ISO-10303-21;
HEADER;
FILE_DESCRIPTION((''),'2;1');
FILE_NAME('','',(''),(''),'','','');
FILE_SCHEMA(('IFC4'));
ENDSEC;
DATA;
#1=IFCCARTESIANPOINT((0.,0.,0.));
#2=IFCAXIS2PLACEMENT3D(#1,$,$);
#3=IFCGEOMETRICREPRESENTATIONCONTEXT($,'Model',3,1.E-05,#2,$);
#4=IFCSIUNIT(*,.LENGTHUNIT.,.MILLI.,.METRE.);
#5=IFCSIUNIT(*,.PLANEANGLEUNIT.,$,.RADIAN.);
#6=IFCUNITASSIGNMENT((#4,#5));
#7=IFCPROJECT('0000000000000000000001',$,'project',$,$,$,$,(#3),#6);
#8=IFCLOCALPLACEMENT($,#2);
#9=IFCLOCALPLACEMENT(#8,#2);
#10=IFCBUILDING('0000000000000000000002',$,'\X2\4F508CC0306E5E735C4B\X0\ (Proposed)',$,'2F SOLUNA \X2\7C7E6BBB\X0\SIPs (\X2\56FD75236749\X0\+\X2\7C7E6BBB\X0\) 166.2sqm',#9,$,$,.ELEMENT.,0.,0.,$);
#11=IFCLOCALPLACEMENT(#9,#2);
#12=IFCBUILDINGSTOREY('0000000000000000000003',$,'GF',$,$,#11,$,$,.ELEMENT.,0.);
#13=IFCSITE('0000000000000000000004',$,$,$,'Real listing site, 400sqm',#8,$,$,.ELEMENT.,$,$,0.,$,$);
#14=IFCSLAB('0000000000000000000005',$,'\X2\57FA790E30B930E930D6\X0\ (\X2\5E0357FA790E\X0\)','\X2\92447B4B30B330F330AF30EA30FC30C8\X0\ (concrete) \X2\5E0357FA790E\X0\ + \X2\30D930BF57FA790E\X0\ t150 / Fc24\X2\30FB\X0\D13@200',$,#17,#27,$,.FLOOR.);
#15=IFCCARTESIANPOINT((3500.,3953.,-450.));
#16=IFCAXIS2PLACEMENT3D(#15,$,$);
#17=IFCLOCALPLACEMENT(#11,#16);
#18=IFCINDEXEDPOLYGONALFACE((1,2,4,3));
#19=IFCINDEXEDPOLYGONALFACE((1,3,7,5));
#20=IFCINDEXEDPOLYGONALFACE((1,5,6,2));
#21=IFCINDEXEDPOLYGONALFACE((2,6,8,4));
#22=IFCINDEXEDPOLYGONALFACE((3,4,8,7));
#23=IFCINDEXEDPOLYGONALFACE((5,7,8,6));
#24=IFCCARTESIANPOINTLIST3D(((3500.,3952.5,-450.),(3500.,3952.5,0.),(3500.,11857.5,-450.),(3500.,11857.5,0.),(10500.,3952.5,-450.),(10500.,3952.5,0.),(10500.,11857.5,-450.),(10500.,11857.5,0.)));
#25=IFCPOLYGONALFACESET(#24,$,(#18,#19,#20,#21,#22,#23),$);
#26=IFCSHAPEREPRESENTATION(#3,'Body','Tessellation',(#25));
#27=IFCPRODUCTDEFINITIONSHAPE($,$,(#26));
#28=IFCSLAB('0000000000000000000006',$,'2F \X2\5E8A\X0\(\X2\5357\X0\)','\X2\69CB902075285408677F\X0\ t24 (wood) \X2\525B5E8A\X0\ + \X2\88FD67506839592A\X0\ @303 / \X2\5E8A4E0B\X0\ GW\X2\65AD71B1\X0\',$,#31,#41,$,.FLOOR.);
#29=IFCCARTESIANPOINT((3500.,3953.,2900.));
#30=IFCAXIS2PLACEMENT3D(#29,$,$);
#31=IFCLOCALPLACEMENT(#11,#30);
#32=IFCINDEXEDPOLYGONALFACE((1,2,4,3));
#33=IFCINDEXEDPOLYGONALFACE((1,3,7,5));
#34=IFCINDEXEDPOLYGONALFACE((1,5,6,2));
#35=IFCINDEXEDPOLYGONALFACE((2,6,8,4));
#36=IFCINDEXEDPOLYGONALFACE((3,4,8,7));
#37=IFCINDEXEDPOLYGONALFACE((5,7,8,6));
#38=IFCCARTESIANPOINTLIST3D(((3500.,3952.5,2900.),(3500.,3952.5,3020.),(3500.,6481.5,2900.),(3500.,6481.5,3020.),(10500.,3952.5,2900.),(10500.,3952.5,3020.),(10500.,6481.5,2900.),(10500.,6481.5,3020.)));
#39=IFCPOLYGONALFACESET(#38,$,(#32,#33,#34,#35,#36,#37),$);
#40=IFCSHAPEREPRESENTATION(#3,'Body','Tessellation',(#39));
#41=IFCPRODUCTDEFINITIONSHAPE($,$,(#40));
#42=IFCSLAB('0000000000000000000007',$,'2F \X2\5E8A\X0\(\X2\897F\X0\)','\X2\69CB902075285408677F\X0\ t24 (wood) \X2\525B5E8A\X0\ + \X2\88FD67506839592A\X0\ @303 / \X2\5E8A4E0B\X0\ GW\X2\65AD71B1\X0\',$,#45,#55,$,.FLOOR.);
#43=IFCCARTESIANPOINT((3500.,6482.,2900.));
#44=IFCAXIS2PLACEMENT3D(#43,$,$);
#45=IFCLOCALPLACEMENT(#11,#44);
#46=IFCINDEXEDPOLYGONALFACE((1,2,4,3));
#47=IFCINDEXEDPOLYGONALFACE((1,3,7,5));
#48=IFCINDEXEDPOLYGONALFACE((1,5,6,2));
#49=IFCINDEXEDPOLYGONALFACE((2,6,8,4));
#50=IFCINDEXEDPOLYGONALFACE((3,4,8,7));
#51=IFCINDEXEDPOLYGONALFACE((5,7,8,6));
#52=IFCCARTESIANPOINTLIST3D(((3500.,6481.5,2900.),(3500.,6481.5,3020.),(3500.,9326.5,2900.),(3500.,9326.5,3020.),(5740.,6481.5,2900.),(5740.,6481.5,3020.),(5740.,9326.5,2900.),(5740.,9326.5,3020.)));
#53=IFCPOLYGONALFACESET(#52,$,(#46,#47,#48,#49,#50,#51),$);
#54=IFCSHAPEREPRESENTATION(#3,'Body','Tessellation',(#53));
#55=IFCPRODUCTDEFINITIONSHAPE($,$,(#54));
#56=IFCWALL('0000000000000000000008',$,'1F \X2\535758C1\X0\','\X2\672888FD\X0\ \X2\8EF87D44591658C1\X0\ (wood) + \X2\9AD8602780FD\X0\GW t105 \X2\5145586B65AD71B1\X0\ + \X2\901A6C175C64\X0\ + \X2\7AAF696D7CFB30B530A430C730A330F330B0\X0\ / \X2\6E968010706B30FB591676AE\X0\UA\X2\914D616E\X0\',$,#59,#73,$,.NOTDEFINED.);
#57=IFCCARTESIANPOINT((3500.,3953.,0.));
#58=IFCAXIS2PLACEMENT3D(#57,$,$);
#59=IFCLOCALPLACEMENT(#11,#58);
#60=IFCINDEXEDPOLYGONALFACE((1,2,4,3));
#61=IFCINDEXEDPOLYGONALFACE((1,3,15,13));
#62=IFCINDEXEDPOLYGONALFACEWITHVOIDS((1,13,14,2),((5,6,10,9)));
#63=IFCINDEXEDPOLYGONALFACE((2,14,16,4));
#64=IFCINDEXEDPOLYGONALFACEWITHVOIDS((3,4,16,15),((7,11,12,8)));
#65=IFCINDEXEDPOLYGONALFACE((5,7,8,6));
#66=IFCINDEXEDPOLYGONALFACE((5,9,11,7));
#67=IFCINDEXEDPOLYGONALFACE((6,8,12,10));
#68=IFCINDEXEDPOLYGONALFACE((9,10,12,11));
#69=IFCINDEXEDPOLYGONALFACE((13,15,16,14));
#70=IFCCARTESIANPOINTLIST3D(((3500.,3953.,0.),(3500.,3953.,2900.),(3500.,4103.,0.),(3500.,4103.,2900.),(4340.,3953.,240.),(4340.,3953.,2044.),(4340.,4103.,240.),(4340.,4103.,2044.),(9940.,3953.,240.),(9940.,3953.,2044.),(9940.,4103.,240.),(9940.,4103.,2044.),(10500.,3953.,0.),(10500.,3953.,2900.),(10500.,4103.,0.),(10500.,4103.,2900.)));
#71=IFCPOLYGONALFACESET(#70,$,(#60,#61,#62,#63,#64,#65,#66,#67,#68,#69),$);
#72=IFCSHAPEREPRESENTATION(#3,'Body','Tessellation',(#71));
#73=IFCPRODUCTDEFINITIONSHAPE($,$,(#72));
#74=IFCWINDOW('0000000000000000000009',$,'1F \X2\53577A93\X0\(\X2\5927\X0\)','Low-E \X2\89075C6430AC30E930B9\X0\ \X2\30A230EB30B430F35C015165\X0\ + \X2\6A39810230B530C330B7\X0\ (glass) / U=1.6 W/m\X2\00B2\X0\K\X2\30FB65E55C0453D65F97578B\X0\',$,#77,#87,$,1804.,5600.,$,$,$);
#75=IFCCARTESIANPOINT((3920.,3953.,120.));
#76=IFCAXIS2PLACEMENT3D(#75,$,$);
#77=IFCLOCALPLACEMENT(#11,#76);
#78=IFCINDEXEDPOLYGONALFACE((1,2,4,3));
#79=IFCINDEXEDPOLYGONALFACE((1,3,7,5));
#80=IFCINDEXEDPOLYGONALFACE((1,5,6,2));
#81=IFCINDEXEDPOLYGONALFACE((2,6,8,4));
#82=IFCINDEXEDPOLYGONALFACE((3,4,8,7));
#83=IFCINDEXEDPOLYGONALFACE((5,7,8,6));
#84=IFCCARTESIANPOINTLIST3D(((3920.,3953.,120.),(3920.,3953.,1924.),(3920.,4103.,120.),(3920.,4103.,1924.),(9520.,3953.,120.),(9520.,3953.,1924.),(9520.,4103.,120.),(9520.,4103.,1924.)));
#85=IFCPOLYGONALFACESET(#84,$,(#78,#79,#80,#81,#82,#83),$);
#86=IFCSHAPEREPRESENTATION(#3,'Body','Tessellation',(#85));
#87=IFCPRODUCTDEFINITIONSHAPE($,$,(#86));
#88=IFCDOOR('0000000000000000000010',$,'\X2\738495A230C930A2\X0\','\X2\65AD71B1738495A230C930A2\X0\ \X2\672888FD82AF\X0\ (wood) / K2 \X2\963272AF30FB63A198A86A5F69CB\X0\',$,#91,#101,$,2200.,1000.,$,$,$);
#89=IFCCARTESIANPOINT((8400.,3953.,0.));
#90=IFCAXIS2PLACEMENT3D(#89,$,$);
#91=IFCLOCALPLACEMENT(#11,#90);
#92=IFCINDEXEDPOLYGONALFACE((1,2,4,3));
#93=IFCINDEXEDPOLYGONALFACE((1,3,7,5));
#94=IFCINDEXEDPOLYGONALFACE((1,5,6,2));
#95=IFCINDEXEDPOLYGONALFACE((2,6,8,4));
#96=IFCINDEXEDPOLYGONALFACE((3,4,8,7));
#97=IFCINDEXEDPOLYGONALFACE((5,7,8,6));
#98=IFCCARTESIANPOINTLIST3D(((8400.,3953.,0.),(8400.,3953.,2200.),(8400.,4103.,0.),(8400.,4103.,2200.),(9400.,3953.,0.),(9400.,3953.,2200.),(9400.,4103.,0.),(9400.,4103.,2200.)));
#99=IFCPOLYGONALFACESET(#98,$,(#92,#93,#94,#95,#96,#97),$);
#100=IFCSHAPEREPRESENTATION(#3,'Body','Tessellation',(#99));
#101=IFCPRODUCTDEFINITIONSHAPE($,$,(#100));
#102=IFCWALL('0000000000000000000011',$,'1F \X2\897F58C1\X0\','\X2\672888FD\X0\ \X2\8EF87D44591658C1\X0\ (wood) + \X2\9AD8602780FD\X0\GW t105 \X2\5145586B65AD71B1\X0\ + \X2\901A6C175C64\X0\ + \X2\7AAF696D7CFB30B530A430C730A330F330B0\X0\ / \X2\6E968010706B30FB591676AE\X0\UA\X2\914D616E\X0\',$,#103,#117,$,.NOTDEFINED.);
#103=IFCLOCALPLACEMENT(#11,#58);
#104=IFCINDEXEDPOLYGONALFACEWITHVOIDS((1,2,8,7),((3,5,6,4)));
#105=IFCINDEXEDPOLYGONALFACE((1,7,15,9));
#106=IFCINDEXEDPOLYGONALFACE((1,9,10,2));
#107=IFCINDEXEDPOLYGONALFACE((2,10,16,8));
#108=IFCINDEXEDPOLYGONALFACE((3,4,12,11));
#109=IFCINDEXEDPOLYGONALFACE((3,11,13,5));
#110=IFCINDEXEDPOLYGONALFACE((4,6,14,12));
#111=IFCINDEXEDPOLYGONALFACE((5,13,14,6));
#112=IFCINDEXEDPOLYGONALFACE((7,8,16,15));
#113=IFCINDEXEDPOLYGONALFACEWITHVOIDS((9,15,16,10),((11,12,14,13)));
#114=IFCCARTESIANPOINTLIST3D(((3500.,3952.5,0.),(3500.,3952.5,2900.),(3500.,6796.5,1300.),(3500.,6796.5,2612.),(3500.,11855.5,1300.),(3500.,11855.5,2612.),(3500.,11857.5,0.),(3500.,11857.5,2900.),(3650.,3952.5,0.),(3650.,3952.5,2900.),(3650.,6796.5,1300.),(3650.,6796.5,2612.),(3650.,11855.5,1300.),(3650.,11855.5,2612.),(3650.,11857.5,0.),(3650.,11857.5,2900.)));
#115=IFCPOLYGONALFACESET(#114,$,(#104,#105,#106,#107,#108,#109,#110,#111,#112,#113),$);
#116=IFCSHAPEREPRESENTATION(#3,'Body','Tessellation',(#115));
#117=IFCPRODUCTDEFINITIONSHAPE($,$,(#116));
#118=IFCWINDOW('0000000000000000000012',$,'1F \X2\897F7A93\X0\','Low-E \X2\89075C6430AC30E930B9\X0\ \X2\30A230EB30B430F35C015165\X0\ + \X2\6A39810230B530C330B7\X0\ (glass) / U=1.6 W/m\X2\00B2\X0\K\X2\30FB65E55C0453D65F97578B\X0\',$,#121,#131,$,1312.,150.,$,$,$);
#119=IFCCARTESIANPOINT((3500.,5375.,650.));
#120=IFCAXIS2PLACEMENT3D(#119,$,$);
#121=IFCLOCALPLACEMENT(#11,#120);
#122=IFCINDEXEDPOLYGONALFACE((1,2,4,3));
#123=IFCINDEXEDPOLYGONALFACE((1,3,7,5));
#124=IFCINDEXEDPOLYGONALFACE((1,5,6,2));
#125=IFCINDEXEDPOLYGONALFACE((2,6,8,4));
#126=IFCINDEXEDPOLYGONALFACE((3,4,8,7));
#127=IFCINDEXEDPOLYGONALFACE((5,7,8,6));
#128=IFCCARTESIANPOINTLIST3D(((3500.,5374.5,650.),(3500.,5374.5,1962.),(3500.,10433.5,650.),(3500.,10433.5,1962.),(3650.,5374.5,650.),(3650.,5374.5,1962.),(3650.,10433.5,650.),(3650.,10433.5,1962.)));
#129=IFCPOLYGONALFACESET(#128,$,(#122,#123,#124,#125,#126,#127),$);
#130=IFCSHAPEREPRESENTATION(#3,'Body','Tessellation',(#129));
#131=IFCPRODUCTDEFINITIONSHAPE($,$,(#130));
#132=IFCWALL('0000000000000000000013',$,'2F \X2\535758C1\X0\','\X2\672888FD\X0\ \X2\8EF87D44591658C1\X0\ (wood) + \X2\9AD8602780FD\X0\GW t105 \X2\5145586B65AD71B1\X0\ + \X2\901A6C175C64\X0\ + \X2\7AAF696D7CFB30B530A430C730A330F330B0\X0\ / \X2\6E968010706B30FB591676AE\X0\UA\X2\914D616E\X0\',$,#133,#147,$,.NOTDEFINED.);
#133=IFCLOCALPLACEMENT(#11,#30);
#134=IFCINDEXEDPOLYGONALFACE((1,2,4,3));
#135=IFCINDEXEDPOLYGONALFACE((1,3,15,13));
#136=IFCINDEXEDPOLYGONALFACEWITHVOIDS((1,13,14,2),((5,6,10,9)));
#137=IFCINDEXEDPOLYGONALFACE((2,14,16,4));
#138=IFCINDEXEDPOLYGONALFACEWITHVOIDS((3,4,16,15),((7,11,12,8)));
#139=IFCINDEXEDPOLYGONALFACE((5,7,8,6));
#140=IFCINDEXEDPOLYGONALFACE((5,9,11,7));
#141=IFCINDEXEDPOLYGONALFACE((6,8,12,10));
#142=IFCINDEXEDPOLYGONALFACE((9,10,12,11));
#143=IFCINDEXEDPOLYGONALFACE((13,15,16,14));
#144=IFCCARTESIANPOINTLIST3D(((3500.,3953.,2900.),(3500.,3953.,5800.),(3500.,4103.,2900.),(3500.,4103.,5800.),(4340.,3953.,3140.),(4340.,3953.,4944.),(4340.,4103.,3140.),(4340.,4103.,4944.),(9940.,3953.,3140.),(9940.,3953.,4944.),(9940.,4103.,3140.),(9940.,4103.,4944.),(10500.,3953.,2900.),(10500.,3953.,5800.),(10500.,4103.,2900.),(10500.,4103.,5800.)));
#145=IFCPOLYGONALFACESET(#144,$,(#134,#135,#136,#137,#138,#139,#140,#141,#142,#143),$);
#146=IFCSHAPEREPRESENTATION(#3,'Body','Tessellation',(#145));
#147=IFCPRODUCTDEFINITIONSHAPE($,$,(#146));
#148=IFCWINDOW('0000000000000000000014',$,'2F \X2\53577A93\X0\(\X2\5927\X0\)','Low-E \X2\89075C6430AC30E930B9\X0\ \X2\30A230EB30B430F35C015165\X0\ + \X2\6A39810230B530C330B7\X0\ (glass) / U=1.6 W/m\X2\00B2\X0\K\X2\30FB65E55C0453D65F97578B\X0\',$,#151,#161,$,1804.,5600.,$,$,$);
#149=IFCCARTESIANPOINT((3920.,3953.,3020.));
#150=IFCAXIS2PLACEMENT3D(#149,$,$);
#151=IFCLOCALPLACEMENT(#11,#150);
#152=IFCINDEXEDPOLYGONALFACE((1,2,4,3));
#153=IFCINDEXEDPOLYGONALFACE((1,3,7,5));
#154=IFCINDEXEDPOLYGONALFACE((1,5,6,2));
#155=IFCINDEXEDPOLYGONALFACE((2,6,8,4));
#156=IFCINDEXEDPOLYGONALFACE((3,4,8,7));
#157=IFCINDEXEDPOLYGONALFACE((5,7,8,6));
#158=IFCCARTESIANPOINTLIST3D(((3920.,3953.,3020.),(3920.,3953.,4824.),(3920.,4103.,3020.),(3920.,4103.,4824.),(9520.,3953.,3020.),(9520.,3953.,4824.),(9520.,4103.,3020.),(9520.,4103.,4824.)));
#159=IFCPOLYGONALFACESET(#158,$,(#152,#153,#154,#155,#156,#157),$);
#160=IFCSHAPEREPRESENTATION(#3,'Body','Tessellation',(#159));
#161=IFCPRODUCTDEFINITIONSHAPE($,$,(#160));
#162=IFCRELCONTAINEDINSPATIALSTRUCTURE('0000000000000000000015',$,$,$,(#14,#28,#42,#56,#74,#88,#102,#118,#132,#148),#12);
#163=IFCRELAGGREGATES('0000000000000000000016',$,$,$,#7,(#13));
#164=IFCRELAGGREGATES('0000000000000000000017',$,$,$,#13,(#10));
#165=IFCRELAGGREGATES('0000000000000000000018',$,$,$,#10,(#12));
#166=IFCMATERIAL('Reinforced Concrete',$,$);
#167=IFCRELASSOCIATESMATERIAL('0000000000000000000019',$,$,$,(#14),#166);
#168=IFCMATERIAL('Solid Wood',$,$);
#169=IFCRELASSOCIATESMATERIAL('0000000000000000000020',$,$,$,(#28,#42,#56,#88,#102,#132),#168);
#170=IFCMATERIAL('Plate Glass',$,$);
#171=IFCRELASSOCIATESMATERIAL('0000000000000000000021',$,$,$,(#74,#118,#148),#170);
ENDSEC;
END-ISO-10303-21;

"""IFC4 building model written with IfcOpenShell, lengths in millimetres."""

from ifc_helpers import new_model, si_unit, frame, frame_2d, origin, place, context, project, spatial, rectangle, extrude, material, element, fill, save


model = new_model("IFC4")

# Units and contexts
model_context = context("Model", 3, precision=1e-05, world=origin())
ifc_project = project(units=[si_unit("LENGTHUNIT", "METRE", prefix="MILLI"), si_unit("PLANEANGLEUNIT", "RADIAN")], contexts=[model_context])

# Site, building, storey
site_placement = place(None, origin())
site = spatial("IfcSite", under=ifc_project, at=site_placement, ObjectType="Real listing site, 400sqm", CompositionType="ELEMENT", RefElevation=0.0)
building_placement = place(site_placement, origin())
building = spatial("IfcBuilding", under=site, at=building_placement, Name="佐賀の平屋 (Proposed)", ObjectType="2F SOLUNA 籾殻SIPs (国産杉+籾殻) 166.2sqm", CompositionType="ELEMENT", ElevationOfRefHeight=0.0, ElevationOfTerrain=0.0)
storey_placement = place(building_placement, origin())
storey = spatial("IfcBuildingStorey", under=building, at=storey_placement, Name="GF", CompositionType="ELEMENT", Elevation=0.0)

# Slabs
ifc_material_1 = material(Name="Reinforced Concrete")
slab_1_placement = place(storey_placement, frame((3500.0, 3953.0, -450.0)))
element("IfcSlab", 1, at=slab_1_placement, inside=storey, material=ifc_material_1, Name="基礎スラブ (布基礎)", Description="鉄筋コンクリート (concrete) 布基礎 + ベタ基礎 t150 / Fc24・D13@200", PredefinedType="FLOOR", context=model_context, shape_type="SweptSolid", body=[
    extrude(rectangle(XDim=7000.0, YDim=7905.0, at=frame_2d((3500.0, 3952.0))), frame((3500.0, 3953.0, -450.0)), (0.0, 0.0, 1.0), 450.0),
])
ifc_material_2 = material(Name="Solid Wood")
slab_2_placement = place(storey_placement, frame((3500.0, 3953.0, 2900.0)))
element("IfcSlab", 2, at=slab_2_placement, inside=storey, material=ifc_material_2, Name="2F 床(南)", Description="構造用合板 t24 (wood) 剛床 + 製材根太 @303 / 床下 GW断熱", PredefinedType="FLOOR", context=model_context, shape_type="SweptSolid", body=[
    extrude(rectangle(XDim=7000.0, YDim=2529.0, at=frame_2d((3500.0, 1264.0))), frame((3500.0, 3953.0, 2900.0)), (0.0, 0.0, 1.0), 120.0),
])
slab_3_placement = place(storey_placement, frame((3500.0, 6482.0, 2900.0)))
element("IfcSlab", 3, at=slab_3_placement, inside=storey, material=ifc_material_2, Name="2F 床(西)", Description="構造用合板 t24 (wood) 剛床 + 製材根太 @303 / 床下 GW断熱", PredefinedType="FLOOR", context=model_context, shape_type="SweptSolid", body=[
    extrude(rectangle(XDim=2240.0, YDim=2845.0, at=frame_2d((1120.0, 1422.0))), frame((3500.0, 6482.0, 2900.0)), (0.0, 0.0, 1.0), 120.0),
])

# Wall, openings, window, door
wall_1_placement = place(storey_placement, frame((3500.0, 3953.0, 0.0)))
wall_1 = element("IfcWall", 4, at=wall_1_placement, inside=storey, material=ifc_material_2, Name="1F 南壁", Description="木製 軸組外壁 (wood) + 高性能GW t105 充填断熱 + 通気層 + 窯業系サイディング / 準耐火・外皮UA配慮", PredefinedType="NOTDEFINED", context=model_context, shape_type="SweptSolid", body=[
    extrude(rectangle(XDim=7000.0, YDim=150.0, at=frame_2d((3500.0, 75.0))), frame((3500.0, 3953.0, 0.0)), (0.0, 0.0, 1.0), 2900.0),
])
opening_1_placement = place(storey_placement, frame((3920.0, 3953.0, 120.0)))
opening_1 = element("IfcOpeningElement", 5, at=opening_1_placement, cuts=wall_1, PredefinedType="NOTDEFINED", context=model_context, shape_type="SweptSolid", body=[
    extrude(rectangle(XDim=5600.0, YDim=150.0, at=frame_2d((2800.0, 75.0))), frame((3920.0, 3953.0, 120.0)), (0.0, 0.0, 1.0), 1804.0),
])
opening_2_placement = place(storey_placement, frame((8400.0, 3953.0, 0.0)))
opening_2 = element("IfcOpeningElement", 6, at=opening_2_placement, cuts=wall_1, PredefinedType="NOTDEFINED", context=model_context, shape_type="SweptSolid", body=[
    extrude(rectangle(XDim=1000.0, YDim=150.0, at=frame_2d((500.0, 75.0))), frame((8400.0, 3953.0, 0.0)), (0.0, 0.0, 1.0), 2200.0),
])
ifc_material_3 = material(Name="Plate Glass")
window_1_placement = place(storey_placement, frame((3920.0, 3953.0, 120.0)))
window_1 = element("IfcWindow", 7, at=window_1_placement, inside=storey, material=ifc_material_3, Name="1F 南窓(大)", Description="Low-E 複層ガラス アルゴン封入 + 樹脂サッシ (glass) / U=1.6 W/m²K・日射取得型", OverallHeight=1804.0, OverallWidth=5600.0, context=model_context, shape_type="SweptSolid", body=[
    extrude(rectangle(XDim=5600.0, YDim=150.0, at=frame_2d((2800.0, 75.0))), frame((3920.0, 3953.0, 120.0)), (0.0, 0.0, 1.0), 1804.0),
])
fill(opening_1, window_1)
door_placement = place(storey_placement, frame((8400.0, 3953.0, 0.0)))
door = element("IfcDoor", 8, at=door_placement, inside=storey, material=ifc_material_2, Name="玄関ドア", Description="断熱玄関ドア 木製芯 (wood) / K2 防犯・採風機構", OverallHeight=2200.0, OverallWidth=1000.0, context=model_context, shape_type="SweptSolid", body=[
    extrude(rectangle(XDim=1000.0, YDim=150.0, at=frame_2d((500.0, 75.0))), frame((8400.0, 3953.0, 0.0)), (0.0, 0.0, 1.0), 2200.0),
])
fill(opening_2, door)

# Walls, openings, windows
wall_2_placement = place(storey_placement, frame((3500.0, 3953.0, 0.0)))
wall_2 = element("IfcWall", 9, at=wall_2_placement, inside=storey, material=ifc_material_2, Name="1F 西壁", Description="木製 軸組外壁 (wood) + 高性能GW t105 充填断熱 + 通気層 + 窯業系サイディング / 準耐火・外皮UA配慮", PredefinedType="NOTDEFINED", context=model_context, shape_type="SweptSolid", body=[
    extrude(rectangle(XDim=150.0, YDim=7905.0, at=frame_2d((75.0, 3952.0))), frame((3500.0, 3953.0, 0.0)), (0.0, 0.0, 1.0), 2900.0),
])
opening_3_placement = place(storey_placement, frame((3500.0, 5375.0, 650.0)))
opening_3 = element("IfcOpeningElement", 10, at=opening_3_placement, cuts=wall_2, PredefinedType="NOTDEFINED", context=model_context, shape_type="SweptSolid", body=[
    extrude(rectangle(XDim=150.0, YDim=5059.0, at=frame_2d((75.0, 2529.0))), frame((3500.0, 5375.0, 650.0)), (0.0, 0.0, 1.0), 1312.0),
])
window_2_placement = place(storey_placement, frame((3500.0, 5375.0, 650.0)))
window_2 = element("IfcWindow", 11, at=window_2_placement, inside=storey, material=ifc_material_3, Name="1F 西窓", Description="Low-E 複層ガラス アルゴン封入 + 樹脂サッシ (glass) / U=1.6 W/m²K・日射取得型", OverallHeight=1312.0, OverallWidth=150.0, context=model_context, shape_type="SweptSolid", body=[
    extrude(rectangle(XDim=150.0, YDim=5059.0, at=frame_2d((75.0, 2529.0))), frame((3500.0, 5375.0, 650.0)), (0.0, 0.0, 1.0), 1312.0),
])
fill(opening_3, window_2)
wall_3_placement = place(storey_placement, frame((3500.0, 3953.0, 2900.0)))
wall_3 = element("IfcWall", 12, at=wall_3_placement, inside=storey, material=ifc_material_2, Name="2F 南壁", Description="木製 軸組外壁 (wood) + 高性能GW t105 充填断熱 + 通気層 + 窯業系サイディング / 準耐火・外皮UA配慮", PredefinedType="NOTDEFINED", context=model_context, shape_type="SweptSolid", body=[
    extrude(rectangle(XDim=7000.0, YDim=150.0, at=frame_2d((3500.0, 75.0))), frame((3500.0, 3953.0, 2900.0)), (0.0, 0.0, 1.0), 2900.0),
])
opening_4_placement = place(storey_placement, frame((3920.0, 3953.0, 3020.0)))
opening_4 = element("IfcOpeningElement", 13, at=opening_4_placement, cuts=wall_3, PredefinedType="NOTDEFINED", context=model_context, shape_type="SweptSolid", body=[
    extrude(rectangle(XDim=5600.0, YDim=150.0, at=frame_2d((2800.0, 75.0))), frame((3920.0, 3953.0, 3020.0)), (0.0, 0.0, 1.0), 1804.0),
])
window_3_placement = place(storey_placement, frame((3920.0, 3953.0, 3020.0)))
window_3 = element("IfcWindow", 14, at=window_3_placement, inside=storey, material=ifc_material_3, Name="2F 南窓(大)", Description="Low-E 複層ガラス アルゴン封入 + 樹脂サッシ (glass) / U=1.6 W/m²K・日射取得型", OverallHeight=1804.0, OverallWidth=5600.0, context=model_context, shape_type="SweptSolid", body=[
    extrude(rectangle(XDim=5600.0, YDim=150.0, at=frame_2d((2800.0, 75.0))), frame((3920.0, 3953.0, 3020.0)), (0.0, 0.0, 1.0), 1804.0),
])
fill(opening_4, window_3)

save(model, "model.ifc")
